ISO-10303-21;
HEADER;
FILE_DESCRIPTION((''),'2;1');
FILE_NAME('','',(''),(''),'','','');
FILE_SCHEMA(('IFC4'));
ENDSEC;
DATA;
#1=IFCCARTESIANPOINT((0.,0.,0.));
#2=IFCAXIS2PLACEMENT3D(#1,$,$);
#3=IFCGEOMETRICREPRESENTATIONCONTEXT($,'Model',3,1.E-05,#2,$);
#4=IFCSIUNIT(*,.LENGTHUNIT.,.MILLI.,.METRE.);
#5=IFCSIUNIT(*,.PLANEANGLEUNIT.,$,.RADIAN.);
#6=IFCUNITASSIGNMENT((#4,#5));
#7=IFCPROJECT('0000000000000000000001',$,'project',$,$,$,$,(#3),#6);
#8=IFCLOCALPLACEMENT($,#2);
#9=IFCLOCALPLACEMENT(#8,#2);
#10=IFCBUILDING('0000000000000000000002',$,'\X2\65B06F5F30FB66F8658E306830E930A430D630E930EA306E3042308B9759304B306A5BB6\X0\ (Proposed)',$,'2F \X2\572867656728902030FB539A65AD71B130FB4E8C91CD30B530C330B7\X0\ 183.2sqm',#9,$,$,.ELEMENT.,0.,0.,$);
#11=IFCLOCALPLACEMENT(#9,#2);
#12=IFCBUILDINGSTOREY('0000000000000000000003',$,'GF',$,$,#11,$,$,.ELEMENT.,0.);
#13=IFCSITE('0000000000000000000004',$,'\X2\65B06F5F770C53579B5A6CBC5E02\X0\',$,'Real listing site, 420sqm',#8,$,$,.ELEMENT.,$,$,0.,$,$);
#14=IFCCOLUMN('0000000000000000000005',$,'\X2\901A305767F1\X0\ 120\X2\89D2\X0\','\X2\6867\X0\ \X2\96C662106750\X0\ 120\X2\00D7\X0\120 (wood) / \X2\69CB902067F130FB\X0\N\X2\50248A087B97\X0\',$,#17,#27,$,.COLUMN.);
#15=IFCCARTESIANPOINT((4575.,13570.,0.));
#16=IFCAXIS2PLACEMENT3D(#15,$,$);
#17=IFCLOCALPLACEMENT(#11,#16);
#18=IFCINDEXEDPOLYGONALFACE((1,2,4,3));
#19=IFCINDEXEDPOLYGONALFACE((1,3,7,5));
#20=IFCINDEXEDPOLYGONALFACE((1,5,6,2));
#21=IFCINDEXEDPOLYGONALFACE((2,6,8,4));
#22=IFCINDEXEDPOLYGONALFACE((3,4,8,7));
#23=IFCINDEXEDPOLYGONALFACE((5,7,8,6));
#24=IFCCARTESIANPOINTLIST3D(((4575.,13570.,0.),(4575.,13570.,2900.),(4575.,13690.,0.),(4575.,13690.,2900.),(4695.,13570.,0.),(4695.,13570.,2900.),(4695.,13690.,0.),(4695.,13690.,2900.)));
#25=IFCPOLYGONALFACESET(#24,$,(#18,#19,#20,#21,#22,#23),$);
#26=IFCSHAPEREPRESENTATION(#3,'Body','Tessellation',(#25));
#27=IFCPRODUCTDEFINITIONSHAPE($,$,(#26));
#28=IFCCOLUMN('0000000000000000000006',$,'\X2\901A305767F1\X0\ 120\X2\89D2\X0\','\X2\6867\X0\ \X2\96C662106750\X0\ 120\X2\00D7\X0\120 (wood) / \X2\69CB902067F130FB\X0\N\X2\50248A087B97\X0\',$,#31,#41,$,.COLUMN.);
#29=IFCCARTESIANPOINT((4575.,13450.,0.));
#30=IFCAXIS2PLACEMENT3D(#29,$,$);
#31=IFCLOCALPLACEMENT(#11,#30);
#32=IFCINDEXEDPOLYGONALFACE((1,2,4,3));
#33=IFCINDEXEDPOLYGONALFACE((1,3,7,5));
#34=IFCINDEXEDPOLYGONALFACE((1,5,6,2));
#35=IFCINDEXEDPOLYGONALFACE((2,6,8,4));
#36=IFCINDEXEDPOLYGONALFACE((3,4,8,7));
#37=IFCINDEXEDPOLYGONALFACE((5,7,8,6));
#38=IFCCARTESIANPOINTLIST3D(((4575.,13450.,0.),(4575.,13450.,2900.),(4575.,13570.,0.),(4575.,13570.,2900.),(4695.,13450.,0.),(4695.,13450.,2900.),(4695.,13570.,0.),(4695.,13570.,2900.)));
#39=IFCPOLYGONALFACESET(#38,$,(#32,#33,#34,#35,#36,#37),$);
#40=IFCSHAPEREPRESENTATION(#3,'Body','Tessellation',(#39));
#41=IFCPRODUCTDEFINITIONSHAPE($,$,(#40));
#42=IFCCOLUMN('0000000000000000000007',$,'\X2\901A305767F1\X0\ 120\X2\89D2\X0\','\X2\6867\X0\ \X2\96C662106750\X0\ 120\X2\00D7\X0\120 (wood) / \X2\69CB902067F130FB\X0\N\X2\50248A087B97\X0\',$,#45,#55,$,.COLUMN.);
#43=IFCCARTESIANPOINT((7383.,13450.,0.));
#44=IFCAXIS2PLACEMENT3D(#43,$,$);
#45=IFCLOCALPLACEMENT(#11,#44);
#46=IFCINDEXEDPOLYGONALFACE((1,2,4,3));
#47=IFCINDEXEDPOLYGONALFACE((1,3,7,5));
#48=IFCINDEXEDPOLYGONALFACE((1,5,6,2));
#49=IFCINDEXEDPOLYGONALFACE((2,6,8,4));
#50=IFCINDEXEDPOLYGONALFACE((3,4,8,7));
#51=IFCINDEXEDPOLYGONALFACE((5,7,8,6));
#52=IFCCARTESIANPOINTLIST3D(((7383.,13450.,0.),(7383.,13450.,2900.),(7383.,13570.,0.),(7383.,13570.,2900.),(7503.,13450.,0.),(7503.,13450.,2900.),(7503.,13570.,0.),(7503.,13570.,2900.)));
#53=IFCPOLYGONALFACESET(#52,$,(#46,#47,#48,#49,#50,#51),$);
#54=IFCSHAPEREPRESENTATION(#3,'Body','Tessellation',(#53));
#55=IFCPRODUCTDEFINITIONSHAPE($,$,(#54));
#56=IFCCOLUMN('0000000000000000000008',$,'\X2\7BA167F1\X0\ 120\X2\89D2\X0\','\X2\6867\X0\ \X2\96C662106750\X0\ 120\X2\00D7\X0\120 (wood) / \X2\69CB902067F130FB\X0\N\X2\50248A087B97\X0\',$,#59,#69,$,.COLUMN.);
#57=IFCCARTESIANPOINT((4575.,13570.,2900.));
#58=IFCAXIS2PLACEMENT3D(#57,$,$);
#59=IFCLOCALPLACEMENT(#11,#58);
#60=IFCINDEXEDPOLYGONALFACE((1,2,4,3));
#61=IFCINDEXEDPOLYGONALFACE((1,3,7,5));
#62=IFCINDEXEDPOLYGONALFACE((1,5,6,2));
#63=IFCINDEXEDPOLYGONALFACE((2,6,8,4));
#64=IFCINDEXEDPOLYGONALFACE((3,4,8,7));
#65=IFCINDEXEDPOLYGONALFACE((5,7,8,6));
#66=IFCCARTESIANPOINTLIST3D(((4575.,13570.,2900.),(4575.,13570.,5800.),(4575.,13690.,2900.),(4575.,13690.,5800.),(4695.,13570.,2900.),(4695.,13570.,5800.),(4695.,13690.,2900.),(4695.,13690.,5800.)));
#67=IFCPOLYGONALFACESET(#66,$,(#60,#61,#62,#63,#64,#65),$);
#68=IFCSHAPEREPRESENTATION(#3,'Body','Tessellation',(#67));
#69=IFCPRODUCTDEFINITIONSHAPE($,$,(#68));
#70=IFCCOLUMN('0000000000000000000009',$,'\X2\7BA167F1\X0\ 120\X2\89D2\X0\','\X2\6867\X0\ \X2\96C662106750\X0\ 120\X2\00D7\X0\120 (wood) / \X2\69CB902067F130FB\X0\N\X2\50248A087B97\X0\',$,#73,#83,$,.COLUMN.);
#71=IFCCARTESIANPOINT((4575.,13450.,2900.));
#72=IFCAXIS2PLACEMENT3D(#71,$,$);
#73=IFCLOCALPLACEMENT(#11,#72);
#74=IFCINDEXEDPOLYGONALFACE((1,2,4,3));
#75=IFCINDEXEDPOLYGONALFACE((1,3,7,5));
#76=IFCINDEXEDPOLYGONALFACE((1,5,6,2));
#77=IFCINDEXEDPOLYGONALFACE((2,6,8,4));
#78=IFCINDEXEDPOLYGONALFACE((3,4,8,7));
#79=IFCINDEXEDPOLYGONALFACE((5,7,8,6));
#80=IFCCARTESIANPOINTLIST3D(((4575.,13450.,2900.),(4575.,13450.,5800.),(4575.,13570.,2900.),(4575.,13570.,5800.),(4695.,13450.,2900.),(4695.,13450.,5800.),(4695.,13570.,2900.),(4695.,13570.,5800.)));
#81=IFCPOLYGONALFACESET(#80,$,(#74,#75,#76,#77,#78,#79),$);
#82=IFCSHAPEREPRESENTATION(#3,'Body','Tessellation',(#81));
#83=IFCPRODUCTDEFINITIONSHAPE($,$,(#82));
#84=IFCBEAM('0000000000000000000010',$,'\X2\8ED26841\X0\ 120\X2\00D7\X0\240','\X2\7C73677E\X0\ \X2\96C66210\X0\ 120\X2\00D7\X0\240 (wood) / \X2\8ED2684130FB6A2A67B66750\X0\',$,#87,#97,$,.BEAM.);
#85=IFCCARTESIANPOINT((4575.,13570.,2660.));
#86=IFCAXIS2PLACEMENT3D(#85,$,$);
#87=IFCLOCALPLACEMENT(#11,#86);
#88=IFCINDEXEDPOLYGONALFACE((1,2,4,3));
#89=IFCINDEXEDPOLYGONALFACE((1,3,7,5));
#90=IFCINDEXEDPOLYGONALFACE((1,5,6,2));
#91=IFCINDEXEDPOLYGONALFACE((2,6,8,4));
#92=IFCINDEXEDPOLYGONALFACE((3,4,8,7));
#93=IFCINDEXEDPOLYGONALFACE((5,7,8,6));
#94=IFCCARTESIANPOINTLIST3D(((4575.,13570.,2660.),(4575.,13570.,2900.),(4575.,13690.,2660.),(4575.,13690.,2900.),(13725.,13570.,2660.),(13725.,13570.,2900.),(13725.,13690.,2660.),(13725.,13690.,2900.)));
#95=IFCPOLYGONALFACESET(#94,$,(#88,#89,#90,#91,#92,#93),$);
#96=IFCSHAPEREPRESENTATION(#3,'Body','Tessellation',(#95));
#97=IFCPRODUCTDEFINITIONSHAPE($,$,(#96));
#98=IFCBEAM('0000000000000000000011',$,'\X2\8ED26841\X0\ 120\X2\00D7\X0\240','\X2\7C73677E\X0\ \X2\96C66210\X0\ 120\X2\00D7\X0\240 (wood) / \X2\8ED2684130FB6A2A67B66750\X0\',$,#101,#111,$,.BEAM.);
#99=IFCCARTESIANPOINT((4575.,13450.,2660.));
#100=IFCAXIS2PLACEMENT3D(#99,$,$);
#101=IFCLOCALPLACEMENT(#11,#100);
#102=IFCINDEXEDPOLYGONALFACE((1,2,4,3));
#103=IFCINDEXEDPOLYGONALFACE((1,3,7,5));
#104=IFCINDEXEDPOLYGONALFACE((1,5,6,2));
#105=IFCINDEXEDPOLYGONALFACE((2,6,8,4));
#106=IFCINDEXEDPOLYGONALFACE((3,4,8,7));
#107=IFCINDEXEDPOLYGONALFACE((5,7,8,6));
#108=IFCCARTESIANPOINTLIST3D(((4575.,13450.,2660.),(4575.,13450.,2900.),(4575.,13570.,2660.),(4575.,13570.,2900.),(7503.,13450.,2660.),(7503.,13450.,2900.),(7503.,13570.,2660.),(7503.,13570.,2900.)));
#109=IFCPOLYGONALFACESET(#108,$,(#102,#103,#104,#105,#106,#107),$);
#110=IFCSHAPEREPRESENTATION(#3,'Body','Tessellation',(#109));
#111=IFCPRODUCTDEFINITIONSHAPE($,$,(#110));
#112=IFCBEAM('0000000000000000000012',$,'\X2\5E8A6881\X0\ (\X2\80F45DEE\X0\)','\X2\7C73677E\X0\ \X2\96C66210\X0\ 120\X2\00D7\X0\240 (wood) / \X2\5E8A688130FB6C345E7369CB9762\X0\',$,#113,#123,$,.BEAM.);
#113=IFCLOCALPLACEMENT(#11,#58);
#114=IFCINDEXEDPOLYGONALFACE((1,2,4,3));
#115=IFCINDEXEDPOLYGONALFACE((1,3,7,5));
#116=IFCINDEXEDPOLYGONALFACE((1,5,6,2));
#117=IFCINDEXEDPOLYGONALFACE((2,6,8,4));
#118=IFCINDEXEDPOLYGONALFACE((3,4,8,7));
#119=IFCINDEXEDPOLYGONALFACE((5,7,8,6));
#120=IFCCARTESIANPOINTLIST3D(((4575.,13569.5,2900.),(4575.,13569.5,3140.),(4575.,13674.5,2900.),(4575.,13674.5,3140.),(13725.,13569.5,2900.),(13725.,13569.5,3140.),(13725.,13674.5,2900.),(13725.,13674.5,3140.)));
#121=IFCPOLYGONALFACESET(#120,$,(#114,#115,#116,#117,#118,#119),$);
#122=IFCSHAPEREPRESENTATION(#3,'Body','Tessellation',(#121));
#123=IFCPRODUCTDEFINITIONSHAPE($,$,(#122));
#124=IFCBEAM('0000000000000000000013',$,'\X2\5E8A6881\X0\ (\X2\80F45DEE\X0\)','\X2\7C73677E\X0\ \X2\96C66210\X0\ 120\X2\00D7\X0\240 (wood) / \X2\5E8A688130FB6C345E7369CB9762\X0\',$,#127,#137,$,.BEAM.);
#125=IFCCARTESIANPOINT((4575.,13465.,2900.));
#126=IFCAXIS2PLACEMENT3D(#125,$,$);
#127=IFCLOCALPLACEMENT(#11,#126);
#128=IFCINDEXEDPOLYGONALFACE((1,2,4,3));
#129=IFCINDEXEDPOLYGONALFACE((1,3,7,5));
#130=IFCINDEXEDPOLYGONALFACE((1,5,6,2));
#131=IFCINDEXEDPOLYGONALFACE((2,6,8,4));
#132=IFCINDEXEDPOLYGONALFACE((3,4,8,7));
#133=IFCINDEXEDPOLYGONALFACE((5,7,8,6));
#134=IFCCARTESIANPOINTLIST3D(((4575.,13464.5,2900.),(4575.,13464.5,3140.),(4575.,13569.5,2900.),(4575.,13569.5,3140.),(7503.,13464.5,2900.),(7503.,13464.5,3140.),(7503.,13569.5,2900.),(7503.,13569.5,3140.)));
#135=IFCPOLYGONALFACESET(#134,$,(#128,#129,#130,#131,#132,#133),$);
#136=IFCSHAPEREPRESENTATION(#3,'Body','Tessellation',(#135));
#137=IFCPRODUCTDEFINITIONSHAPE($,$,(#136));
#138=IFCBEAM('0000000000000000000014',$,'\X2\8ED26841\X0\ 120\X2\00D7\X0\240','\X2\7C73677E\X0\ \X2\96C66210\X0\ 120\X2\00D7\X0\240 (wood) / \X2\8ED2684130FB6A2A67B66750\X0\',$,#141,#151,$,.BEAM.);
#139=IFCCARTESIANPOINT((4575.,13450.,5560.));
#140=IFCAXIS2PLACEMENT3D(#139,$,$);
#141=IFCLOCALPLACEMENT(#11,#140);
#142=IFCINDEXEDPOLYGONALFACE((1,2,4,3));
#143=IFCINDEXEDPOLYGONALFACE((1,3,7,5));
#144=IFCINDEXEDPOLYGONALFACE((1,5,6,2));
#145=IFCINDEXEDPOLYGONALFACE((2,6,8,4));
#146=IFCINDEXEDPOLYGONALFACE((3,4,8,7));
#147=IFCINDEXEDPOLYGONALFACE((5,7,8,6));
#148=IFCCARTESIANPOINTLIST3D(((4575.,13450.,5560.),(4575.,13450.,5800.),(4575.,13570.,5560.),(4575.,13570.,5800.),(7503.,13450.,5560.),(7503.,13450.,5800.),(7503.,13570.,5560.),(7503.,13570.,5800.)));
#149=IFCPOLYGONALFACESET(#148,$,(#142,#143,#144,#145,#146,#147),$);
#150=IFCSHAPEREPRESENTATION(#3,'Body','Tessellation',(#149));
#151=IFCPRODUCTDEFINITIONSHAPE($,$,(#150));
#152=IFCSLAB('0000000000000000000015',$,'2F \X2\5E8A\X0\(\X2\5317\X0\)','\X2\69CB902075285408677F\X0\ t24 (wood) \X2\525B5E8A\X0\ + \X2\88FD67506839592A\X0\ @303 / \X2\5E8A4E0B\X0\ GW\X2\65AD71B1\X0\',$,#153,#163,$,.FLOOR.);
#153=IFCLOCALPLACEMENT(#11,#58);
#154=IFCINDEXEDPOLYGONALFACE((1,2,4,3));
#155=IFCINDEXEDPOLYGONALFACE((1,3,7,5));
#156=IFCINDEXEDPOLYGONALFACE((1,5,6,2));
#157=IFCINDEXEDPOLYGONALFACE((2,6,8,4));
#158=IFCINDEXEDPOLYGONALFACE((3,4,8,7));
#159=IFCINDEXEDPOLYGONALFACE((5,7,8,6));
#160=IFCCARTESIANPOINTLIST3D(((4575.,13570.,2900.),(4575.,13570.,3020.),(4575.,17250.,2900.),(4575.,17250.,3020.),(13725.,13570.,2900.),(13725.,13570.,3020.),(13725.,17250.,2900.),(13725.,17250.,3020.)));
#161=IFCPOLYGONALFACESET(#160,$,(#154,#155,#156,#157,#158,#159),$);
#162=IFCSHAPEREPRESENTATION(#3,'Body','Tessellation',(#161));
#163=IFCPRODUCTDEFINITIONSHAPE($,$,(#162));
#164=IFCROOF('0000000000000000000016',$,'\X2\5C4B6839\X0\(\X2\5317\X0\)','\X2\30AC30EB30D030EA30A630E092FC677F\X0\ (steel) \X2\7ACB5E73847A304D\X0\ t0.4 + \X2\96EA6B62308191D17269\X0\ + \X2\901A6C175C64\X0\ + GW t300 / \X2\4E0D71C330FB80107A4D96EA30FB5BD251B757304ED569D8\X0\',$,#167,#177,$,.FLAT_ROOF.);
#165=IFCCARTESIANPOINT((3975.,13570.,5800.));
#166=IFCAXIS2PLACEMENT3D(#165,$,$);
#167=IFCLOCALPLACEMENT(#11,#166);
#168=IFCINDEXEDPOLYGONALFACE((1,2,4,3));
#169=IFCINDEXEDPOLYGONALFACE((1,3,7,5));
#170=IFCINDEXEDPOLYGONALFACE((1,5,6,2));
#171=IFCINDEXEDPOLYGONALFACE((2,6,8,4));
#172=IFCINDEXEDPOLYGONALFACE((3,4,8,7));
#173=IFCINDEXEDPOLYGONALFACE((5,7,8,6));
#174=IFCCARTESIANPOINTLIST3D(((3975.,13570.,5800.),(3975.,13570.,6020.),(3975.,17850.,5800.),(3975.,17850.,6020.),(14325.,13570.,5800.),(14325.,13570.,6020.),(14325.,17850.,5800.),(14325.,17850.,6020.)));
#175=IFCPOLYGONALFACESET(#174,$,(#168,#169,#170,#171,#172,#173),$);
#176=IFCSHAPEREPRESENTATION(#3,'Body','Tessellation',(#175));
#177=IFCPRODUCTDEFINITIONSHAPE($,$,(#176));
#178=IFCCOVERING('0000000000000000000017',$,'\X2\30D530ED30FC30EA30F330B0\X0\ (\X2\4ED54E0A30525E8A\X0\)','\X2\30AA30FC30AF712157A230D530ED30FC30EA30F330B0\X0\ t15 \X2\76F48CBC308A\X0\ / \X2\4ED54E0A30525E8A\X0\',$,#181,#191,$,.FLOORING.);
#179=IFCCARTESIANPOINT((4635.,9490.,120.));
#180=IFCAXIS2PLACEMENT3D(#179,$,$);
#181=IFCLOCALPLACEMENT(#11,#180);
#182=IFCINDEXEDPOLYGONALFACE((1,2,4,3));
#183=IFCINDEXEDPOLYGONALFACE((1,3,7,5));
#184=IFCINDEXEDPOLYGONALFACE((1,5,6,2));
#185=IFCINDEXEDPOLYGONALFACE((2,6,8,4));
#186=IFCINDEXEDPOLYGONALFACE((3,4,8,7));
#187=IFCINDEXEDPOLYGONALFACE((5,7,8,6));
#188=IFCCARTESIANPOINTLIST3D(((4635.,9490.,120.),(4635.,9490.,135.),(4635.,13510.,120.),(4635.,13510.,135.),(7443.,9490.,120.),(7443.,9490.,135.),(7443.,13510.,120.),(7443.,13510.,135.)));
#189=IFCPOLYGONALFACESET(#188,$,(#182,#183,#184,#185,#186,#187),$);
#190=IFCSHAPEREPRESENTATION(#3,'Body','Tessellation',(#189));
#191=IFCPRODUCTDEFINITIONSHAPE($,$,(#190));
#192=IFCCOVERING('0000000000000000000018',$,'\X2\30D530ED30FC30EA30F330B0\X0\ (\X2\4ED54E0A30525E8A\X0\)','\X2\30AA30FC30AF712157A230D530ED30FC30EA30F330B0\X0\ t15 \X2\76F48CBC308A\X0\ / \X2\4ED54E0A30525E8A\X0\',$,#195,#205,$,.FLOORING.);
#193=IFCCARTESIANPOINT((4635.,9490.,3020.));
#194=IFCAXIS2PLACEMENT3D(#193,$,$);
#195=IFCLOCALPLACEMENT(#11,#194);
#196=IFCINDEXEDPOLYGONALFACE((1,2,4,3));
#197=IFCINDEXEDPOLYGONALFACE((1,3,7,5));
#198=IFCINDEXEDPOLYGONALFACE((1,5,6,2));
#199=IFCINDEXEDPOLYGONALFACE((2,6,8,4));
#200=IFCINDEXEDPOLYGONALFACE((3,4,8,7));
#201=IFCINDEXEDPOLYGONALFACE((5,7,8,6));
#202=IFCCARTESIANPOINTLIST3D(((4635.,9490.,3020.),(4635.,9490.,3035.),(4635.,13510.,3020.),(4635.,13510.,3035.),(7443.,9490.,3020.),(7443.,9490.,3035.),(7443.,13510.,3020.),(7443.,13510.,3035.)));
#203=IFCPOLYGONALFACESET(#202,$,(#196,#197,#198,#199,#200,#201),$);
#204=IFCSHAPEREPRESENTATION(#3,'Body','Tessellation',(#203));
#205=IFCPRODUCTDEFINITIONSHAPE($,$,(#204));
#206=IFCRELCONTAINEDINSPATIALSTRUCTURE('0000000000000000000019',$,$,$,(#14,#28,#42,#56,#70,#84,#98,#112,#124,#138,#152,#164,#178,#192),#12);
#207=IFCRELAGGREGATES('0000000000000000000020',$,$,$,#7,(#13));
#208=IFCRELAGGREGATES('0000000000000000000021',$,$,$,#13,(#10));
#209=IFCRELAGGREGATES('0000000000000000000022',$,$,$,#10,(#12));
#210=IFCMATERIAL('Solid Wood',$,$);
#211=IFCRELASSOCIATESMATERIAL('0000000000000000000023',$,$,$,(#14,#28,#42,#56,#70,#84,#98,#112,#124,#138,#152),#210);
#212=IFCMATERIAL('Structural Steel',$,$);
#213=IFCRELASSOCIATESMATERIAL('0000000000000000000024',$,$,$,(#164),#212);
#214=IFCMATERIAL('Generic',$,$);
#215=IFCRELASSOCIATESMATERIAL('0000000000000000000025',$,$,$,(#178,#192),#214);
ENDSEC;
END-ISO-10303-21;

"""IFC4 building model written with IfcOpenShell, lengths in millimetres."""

from ifc_helpers import new_model, si_unit, frame, frame_2d, origin, place, context, project, spatial, rectangle, extrude, material, element, save


model = new_model("IFC4")

# Units and contexts
model_context = context("Model", 3, precision=1e-05, world=origin())
ifc_project = project(units=[si_unit("LENGTHUNIT", "METRE", prefix="MILLI"), si_unit("PLANEANGLEUNIT", "RADIAN")], contexts=[model_context])

# Site, building, storey
site_placement = place(None, origin())
site = spatial("IfcSite", under=ifc_project, at=site_placement, Name="新潟県南魚沼市", ObjectType="Real listing site, 420sqm", CompositionType="ELEMENT", RefElevation=0.0)
building_placement = place(site_placement, origin())
building = spatial("IfcBuilding", under=site, at=building_placement, Name="新潟・書斎とライブラリのある静かな家 (Proposed)", ObjectType="2F 在来木造・厚断熱・二重サッシ 183.2sqm", CompositionType="ELEMENT", ElevationOfRefHeight=0.0, ElevationOfTerrain=0.0)
storey_placement = place(building_placement, origin())
storey = spatial("IfcBuildingStorey", under=building, at=storey_placement, Name="GF", CompositionType="ELEMENT", Elevation=0.0)

# Columns
ifc_material_1 = material(Name="Solid Wood")
column_1_placement = place(storey_placement, frame((4575.0, 13570.0, 0.0)))
element("IfcColumn", 1, at=column_1_placement, inside=storey, material=ifc_material_1, Name="通し柱 120角", Description="桧 集成材 120×120 (wood) / 構造柱・N値計算", PredefinedType="COLUMN", context=model_context, shape_type="SweptSolid", body=[
    extrude(rectangle(XDim=120.0, YDim=120.0, at=frame_2d((60.0, 60.0))), frame((4575.0, 13570.0, 0.0)), (0.0, 0.0, 1.0), 2900.0),
])
column_2_placement = place(storey_placement, frame((4575.0, 13450.0, 0.0)))
element("IfcColumn", 2, at=column_2_placement, inside=storey, material=ifc_material_1, Name="通し柱 120角", Description="桧 集成材 120×120 (wood) / 構造柱・N値計算", PredefinedType="COLUMN", context=model_context, shape_type="SweptSolid", body=[
    extrude(rectangle(XDim=120.0, YDim=120.0, at=frame_2d((60.0, 60.0))), frame((4575.0, 13450.0, 0.0)), (0.0, 0.0, 1.0), 2900.0),
])
column_3_placement = place(storey_placement, frame((7383.0, 13450.0, 0.0)))
element("IfcColumn", 3, at=column_3_placement, inside=storey, material=ifc_material_1, Name="通し柱 120角", Description="桧 集成材 120×120 (wood) / 構造柱・N値計算", PredefinedType="COLUMN", context=model_context, shape_type="SweptSolid", body=[
    extrude(rectangle(XDim=120.0, YDim=120.0, at=frame_2d((60.0, 60.0))), frame((7383.0, 13450.0, 0.0)), (0.0, 0.0, 1.0), 2900.0),
])
column_4_placement = place(storey_placement, frame((4575.0, 13570.0, 2900.0)))
element("IfcColumn", 4, at=column_4_placement, inside=storey, material=ifc_material_1, Name="管柱 120角", Description="桧 集成材 120×120 (wood) / 構造柱・N値計算", PredefinedType="COLUMN", context=model_context, shape_type="SweptSolid", body=[
    extrude(rectangle(XDim=120.0, YDim=120.0, at=frame_2d((60.0, 60.0))), frame((4575.0, 13570.0, 2900.0)), (0.0, 0.0, 1.0), 2900.0),
])
column_5_placement = place(storey_placement, frame((4575.0, 13450.0, 2900.0)))
element("IfcColumn", 5, at=column_5_placement, inside=storey, material=ifc_material_1, Name="管柱 120角", Description="桧 集成材 120×120 (wood) / 構造柱・N値計算", PredefinedType="COLUMN", context=model_context, shape_type="SweptSolid", body=[
    extrude(rectangle(XDim=120.0, YDim=120.0, at=frame_2d((60.0, 60.0))), frame((4575.0, 13450.0, 2900.0)), (0.0, 0.0, 1.0), 2900.0),
])

# Beams
beam_1_placement = place(storey_placement, frame((4575.0, 13570.0, 2660.0)))
element("IfcBeam", 6, at=beam_1_placement, inside=storey, material=ifc_material_1, Name="軒桁 120×240", Description="米松 集成 120×240 (wood) / 軒桁・横架材", PredefinedType="BEAM", context=model_context, shape_type="SweptSolid", body=[
    extrude(rectangle(XDim=9150.0, YDim=120.0, at=frame_2d((4575.0, 60.0))), frame((4575.0, 13570.0, 2660.0)), (0.0, 0.0, 1.0), 240.0),
])
beam_2_placement = place(storey_placement, frame((4575.0, 13450.0, 2660.0)))
element("IfcBeam", 7, at=beam_2_placement, inside=storey, material=ifc_material_1, Name="軒桁 120×240", Description="米松 集成 120×240 (wood) / 軒桁・横架材", PredefinedType="BEAM", context=model_context, shape_type="SweptSolid", body=[
    extrude(rectangle(XDim=2928.0, YDim=120.0, at=frame_2d((1464.0, 60.0))), frame((4575.0, 13450.0, 2660.0)), (0.0, 0.0, 1.0), 240.0),
])
beam_3_placement = place(storey_placement, frame((4575.0, 13570.0, 2900.0)))
element("IfcBeam", 8, at=beam_3_placement, inside=storey, material=ifc_material_1, Name="床梁 (胴差)", Description="米松 集成 120×240 (wood) / 床梁・水平構面", PredefinedType="BEAM", context=model_context, shape_type="SweptSolid", body=[
    extrude(rectangle(XDim=9150.0, YDim=105.0, at=frame_2d((4575.0, 52.0))), frame((4575.0, 13570.0, 2900.0)), (0.0, 0.0, 1.0), 240.0),
])
beam_4_placement = place(storey_placement, frame((4575.0, 13465.0, 2900.0)))
element("IfcBeam", 9, at=beam_4_placement, inside=storey, material=ifc_material_1, Name="床梁 (胴差)", Description="米松 集成 120×240 (wood) / 床梁・水平構面", PredefinedType="BEAM", context=model_context, shape_type="SweptSolid", body=[
    extrude(rectangle(XDim=2928.0, YDim=105.0, at=frame_2d((1464.0, 52.0))), frame((4575.0, 13465.0, 2900.0)), (0.0, 0.0, 1.0), 240.0),
])
beam_5_placement = place(storey_placement, frame((4575.0, 13450.0, 5560.0)))
element("IfcBeam", 10, at=beam_5_placement, inside=storey, material=ifc_material_1, Name="軒桁 120×240", Description="米松 集成 120×240 (wood) / 軒桁・横架材", PredefinedType="BEAM", context=model_context, shape_type="SweptSolid", body=[
    extrude(rectangle(XDim=2928.0, YDim=120.0, at=frame_2d((1464.0, 60.0))), frame((4575.0, 13450.0, 5560.0)), (0.0, 0.0, 1.0), 240.0),
])

# Slab
slab_1_placement = place(storey_placement, frame((4575.0, 13570.0, 2900.0)))
element("IfcSlab", 11, at=slab_1_placement, inside=storey, material=ifc_material_1, Name="2F 床(北)", Description="構造用合板 t24 (wood) 剛床 + 製材根太 @303 / 床下 GW断熱", PredefinedType="FLOOR", context=model_context, shape_type="SweptSolid", body=[
    extrude(rectangle(XDim=9150.0, YDim=3680.0, at=frame_2d((4575.0, 1840.0))), frame((4575.0, 13570.0, 2900.0)), (0.0, 0.0, 1.0), 120.0),
])

# Roof
ifc_material_2 = material(Name="Structural Steel")
for number, where, name in (
    (12, (3975.0, 13570.0, 5800.0), "屋根(北)"),
):
    element("IfcRoof", number, at=place(storey_placement, frame(where)), inside=storey, material=ifc_material_2, Name=name, Description="ガルバリウム鋼板 (steel) 立平葺き t0.4 + 雪止め金物 + 通気層 + GW t300 / 不燃・耐積雪・寒冷地仕様", PredefinedType="FLAT_ROOF", context=model_context, shape_type="SweptSolid", body=[
        extrude(rectangle(XDim=10350.0, YDim=4280.0, at=frame_2d((5175.0, 2140.0))), frame((3975.0, 13570.0, 5800.0)), (0.0, 0.0, 1.0), 220.0),
    ])

# Coverings
ifc_material_3 = material(Name="Generic")
covering_1_placement = place(storey_placement, frame((4635.0, 9490.0, 120.0)))
element("IfcCovering", 13, at=covering_1_placement, inside=storey, material=ifc_material_3, Name="フローリング (仕上げ床)", Description="オーク無垢フローリング t15 直貼り / 仕上げ床", PredefinedType="FLOORING", context=model_context, shape_type="SweptSolid", body=[
    extrude(rectangle(XDim=2808.0, YDim=4020.0, at=frame_2d((1404.0, 2010.0))), frame((4635.0, 9490.0, 120.0)), (0.0, 0.0, 1.0), 15.0),
])
covering_2_placement = place(storey_placement, frame((4635.0, 9490.0, 3020.0)))
element("IfcCovering", 14, at=covering_2_placement, inside=storey, material=ifc_material_3, Name="フローリング (仕上げ床)", Description="オーク無垢フローリング t15 直貼り / 仕上げ床", PredefinedType="FLOORING", context=model_context, shape_type="SweptSolid", body=[
    extrude(rectangle(XDim=2808.0, YDim=4020.0, at=frame_2d((1404.0, 2010.0))), frame((4635.0, 9490.0, 3020.0)), (0.0, 0.0, 1.0), 15.0),
])

save(model, "model.ifc")
